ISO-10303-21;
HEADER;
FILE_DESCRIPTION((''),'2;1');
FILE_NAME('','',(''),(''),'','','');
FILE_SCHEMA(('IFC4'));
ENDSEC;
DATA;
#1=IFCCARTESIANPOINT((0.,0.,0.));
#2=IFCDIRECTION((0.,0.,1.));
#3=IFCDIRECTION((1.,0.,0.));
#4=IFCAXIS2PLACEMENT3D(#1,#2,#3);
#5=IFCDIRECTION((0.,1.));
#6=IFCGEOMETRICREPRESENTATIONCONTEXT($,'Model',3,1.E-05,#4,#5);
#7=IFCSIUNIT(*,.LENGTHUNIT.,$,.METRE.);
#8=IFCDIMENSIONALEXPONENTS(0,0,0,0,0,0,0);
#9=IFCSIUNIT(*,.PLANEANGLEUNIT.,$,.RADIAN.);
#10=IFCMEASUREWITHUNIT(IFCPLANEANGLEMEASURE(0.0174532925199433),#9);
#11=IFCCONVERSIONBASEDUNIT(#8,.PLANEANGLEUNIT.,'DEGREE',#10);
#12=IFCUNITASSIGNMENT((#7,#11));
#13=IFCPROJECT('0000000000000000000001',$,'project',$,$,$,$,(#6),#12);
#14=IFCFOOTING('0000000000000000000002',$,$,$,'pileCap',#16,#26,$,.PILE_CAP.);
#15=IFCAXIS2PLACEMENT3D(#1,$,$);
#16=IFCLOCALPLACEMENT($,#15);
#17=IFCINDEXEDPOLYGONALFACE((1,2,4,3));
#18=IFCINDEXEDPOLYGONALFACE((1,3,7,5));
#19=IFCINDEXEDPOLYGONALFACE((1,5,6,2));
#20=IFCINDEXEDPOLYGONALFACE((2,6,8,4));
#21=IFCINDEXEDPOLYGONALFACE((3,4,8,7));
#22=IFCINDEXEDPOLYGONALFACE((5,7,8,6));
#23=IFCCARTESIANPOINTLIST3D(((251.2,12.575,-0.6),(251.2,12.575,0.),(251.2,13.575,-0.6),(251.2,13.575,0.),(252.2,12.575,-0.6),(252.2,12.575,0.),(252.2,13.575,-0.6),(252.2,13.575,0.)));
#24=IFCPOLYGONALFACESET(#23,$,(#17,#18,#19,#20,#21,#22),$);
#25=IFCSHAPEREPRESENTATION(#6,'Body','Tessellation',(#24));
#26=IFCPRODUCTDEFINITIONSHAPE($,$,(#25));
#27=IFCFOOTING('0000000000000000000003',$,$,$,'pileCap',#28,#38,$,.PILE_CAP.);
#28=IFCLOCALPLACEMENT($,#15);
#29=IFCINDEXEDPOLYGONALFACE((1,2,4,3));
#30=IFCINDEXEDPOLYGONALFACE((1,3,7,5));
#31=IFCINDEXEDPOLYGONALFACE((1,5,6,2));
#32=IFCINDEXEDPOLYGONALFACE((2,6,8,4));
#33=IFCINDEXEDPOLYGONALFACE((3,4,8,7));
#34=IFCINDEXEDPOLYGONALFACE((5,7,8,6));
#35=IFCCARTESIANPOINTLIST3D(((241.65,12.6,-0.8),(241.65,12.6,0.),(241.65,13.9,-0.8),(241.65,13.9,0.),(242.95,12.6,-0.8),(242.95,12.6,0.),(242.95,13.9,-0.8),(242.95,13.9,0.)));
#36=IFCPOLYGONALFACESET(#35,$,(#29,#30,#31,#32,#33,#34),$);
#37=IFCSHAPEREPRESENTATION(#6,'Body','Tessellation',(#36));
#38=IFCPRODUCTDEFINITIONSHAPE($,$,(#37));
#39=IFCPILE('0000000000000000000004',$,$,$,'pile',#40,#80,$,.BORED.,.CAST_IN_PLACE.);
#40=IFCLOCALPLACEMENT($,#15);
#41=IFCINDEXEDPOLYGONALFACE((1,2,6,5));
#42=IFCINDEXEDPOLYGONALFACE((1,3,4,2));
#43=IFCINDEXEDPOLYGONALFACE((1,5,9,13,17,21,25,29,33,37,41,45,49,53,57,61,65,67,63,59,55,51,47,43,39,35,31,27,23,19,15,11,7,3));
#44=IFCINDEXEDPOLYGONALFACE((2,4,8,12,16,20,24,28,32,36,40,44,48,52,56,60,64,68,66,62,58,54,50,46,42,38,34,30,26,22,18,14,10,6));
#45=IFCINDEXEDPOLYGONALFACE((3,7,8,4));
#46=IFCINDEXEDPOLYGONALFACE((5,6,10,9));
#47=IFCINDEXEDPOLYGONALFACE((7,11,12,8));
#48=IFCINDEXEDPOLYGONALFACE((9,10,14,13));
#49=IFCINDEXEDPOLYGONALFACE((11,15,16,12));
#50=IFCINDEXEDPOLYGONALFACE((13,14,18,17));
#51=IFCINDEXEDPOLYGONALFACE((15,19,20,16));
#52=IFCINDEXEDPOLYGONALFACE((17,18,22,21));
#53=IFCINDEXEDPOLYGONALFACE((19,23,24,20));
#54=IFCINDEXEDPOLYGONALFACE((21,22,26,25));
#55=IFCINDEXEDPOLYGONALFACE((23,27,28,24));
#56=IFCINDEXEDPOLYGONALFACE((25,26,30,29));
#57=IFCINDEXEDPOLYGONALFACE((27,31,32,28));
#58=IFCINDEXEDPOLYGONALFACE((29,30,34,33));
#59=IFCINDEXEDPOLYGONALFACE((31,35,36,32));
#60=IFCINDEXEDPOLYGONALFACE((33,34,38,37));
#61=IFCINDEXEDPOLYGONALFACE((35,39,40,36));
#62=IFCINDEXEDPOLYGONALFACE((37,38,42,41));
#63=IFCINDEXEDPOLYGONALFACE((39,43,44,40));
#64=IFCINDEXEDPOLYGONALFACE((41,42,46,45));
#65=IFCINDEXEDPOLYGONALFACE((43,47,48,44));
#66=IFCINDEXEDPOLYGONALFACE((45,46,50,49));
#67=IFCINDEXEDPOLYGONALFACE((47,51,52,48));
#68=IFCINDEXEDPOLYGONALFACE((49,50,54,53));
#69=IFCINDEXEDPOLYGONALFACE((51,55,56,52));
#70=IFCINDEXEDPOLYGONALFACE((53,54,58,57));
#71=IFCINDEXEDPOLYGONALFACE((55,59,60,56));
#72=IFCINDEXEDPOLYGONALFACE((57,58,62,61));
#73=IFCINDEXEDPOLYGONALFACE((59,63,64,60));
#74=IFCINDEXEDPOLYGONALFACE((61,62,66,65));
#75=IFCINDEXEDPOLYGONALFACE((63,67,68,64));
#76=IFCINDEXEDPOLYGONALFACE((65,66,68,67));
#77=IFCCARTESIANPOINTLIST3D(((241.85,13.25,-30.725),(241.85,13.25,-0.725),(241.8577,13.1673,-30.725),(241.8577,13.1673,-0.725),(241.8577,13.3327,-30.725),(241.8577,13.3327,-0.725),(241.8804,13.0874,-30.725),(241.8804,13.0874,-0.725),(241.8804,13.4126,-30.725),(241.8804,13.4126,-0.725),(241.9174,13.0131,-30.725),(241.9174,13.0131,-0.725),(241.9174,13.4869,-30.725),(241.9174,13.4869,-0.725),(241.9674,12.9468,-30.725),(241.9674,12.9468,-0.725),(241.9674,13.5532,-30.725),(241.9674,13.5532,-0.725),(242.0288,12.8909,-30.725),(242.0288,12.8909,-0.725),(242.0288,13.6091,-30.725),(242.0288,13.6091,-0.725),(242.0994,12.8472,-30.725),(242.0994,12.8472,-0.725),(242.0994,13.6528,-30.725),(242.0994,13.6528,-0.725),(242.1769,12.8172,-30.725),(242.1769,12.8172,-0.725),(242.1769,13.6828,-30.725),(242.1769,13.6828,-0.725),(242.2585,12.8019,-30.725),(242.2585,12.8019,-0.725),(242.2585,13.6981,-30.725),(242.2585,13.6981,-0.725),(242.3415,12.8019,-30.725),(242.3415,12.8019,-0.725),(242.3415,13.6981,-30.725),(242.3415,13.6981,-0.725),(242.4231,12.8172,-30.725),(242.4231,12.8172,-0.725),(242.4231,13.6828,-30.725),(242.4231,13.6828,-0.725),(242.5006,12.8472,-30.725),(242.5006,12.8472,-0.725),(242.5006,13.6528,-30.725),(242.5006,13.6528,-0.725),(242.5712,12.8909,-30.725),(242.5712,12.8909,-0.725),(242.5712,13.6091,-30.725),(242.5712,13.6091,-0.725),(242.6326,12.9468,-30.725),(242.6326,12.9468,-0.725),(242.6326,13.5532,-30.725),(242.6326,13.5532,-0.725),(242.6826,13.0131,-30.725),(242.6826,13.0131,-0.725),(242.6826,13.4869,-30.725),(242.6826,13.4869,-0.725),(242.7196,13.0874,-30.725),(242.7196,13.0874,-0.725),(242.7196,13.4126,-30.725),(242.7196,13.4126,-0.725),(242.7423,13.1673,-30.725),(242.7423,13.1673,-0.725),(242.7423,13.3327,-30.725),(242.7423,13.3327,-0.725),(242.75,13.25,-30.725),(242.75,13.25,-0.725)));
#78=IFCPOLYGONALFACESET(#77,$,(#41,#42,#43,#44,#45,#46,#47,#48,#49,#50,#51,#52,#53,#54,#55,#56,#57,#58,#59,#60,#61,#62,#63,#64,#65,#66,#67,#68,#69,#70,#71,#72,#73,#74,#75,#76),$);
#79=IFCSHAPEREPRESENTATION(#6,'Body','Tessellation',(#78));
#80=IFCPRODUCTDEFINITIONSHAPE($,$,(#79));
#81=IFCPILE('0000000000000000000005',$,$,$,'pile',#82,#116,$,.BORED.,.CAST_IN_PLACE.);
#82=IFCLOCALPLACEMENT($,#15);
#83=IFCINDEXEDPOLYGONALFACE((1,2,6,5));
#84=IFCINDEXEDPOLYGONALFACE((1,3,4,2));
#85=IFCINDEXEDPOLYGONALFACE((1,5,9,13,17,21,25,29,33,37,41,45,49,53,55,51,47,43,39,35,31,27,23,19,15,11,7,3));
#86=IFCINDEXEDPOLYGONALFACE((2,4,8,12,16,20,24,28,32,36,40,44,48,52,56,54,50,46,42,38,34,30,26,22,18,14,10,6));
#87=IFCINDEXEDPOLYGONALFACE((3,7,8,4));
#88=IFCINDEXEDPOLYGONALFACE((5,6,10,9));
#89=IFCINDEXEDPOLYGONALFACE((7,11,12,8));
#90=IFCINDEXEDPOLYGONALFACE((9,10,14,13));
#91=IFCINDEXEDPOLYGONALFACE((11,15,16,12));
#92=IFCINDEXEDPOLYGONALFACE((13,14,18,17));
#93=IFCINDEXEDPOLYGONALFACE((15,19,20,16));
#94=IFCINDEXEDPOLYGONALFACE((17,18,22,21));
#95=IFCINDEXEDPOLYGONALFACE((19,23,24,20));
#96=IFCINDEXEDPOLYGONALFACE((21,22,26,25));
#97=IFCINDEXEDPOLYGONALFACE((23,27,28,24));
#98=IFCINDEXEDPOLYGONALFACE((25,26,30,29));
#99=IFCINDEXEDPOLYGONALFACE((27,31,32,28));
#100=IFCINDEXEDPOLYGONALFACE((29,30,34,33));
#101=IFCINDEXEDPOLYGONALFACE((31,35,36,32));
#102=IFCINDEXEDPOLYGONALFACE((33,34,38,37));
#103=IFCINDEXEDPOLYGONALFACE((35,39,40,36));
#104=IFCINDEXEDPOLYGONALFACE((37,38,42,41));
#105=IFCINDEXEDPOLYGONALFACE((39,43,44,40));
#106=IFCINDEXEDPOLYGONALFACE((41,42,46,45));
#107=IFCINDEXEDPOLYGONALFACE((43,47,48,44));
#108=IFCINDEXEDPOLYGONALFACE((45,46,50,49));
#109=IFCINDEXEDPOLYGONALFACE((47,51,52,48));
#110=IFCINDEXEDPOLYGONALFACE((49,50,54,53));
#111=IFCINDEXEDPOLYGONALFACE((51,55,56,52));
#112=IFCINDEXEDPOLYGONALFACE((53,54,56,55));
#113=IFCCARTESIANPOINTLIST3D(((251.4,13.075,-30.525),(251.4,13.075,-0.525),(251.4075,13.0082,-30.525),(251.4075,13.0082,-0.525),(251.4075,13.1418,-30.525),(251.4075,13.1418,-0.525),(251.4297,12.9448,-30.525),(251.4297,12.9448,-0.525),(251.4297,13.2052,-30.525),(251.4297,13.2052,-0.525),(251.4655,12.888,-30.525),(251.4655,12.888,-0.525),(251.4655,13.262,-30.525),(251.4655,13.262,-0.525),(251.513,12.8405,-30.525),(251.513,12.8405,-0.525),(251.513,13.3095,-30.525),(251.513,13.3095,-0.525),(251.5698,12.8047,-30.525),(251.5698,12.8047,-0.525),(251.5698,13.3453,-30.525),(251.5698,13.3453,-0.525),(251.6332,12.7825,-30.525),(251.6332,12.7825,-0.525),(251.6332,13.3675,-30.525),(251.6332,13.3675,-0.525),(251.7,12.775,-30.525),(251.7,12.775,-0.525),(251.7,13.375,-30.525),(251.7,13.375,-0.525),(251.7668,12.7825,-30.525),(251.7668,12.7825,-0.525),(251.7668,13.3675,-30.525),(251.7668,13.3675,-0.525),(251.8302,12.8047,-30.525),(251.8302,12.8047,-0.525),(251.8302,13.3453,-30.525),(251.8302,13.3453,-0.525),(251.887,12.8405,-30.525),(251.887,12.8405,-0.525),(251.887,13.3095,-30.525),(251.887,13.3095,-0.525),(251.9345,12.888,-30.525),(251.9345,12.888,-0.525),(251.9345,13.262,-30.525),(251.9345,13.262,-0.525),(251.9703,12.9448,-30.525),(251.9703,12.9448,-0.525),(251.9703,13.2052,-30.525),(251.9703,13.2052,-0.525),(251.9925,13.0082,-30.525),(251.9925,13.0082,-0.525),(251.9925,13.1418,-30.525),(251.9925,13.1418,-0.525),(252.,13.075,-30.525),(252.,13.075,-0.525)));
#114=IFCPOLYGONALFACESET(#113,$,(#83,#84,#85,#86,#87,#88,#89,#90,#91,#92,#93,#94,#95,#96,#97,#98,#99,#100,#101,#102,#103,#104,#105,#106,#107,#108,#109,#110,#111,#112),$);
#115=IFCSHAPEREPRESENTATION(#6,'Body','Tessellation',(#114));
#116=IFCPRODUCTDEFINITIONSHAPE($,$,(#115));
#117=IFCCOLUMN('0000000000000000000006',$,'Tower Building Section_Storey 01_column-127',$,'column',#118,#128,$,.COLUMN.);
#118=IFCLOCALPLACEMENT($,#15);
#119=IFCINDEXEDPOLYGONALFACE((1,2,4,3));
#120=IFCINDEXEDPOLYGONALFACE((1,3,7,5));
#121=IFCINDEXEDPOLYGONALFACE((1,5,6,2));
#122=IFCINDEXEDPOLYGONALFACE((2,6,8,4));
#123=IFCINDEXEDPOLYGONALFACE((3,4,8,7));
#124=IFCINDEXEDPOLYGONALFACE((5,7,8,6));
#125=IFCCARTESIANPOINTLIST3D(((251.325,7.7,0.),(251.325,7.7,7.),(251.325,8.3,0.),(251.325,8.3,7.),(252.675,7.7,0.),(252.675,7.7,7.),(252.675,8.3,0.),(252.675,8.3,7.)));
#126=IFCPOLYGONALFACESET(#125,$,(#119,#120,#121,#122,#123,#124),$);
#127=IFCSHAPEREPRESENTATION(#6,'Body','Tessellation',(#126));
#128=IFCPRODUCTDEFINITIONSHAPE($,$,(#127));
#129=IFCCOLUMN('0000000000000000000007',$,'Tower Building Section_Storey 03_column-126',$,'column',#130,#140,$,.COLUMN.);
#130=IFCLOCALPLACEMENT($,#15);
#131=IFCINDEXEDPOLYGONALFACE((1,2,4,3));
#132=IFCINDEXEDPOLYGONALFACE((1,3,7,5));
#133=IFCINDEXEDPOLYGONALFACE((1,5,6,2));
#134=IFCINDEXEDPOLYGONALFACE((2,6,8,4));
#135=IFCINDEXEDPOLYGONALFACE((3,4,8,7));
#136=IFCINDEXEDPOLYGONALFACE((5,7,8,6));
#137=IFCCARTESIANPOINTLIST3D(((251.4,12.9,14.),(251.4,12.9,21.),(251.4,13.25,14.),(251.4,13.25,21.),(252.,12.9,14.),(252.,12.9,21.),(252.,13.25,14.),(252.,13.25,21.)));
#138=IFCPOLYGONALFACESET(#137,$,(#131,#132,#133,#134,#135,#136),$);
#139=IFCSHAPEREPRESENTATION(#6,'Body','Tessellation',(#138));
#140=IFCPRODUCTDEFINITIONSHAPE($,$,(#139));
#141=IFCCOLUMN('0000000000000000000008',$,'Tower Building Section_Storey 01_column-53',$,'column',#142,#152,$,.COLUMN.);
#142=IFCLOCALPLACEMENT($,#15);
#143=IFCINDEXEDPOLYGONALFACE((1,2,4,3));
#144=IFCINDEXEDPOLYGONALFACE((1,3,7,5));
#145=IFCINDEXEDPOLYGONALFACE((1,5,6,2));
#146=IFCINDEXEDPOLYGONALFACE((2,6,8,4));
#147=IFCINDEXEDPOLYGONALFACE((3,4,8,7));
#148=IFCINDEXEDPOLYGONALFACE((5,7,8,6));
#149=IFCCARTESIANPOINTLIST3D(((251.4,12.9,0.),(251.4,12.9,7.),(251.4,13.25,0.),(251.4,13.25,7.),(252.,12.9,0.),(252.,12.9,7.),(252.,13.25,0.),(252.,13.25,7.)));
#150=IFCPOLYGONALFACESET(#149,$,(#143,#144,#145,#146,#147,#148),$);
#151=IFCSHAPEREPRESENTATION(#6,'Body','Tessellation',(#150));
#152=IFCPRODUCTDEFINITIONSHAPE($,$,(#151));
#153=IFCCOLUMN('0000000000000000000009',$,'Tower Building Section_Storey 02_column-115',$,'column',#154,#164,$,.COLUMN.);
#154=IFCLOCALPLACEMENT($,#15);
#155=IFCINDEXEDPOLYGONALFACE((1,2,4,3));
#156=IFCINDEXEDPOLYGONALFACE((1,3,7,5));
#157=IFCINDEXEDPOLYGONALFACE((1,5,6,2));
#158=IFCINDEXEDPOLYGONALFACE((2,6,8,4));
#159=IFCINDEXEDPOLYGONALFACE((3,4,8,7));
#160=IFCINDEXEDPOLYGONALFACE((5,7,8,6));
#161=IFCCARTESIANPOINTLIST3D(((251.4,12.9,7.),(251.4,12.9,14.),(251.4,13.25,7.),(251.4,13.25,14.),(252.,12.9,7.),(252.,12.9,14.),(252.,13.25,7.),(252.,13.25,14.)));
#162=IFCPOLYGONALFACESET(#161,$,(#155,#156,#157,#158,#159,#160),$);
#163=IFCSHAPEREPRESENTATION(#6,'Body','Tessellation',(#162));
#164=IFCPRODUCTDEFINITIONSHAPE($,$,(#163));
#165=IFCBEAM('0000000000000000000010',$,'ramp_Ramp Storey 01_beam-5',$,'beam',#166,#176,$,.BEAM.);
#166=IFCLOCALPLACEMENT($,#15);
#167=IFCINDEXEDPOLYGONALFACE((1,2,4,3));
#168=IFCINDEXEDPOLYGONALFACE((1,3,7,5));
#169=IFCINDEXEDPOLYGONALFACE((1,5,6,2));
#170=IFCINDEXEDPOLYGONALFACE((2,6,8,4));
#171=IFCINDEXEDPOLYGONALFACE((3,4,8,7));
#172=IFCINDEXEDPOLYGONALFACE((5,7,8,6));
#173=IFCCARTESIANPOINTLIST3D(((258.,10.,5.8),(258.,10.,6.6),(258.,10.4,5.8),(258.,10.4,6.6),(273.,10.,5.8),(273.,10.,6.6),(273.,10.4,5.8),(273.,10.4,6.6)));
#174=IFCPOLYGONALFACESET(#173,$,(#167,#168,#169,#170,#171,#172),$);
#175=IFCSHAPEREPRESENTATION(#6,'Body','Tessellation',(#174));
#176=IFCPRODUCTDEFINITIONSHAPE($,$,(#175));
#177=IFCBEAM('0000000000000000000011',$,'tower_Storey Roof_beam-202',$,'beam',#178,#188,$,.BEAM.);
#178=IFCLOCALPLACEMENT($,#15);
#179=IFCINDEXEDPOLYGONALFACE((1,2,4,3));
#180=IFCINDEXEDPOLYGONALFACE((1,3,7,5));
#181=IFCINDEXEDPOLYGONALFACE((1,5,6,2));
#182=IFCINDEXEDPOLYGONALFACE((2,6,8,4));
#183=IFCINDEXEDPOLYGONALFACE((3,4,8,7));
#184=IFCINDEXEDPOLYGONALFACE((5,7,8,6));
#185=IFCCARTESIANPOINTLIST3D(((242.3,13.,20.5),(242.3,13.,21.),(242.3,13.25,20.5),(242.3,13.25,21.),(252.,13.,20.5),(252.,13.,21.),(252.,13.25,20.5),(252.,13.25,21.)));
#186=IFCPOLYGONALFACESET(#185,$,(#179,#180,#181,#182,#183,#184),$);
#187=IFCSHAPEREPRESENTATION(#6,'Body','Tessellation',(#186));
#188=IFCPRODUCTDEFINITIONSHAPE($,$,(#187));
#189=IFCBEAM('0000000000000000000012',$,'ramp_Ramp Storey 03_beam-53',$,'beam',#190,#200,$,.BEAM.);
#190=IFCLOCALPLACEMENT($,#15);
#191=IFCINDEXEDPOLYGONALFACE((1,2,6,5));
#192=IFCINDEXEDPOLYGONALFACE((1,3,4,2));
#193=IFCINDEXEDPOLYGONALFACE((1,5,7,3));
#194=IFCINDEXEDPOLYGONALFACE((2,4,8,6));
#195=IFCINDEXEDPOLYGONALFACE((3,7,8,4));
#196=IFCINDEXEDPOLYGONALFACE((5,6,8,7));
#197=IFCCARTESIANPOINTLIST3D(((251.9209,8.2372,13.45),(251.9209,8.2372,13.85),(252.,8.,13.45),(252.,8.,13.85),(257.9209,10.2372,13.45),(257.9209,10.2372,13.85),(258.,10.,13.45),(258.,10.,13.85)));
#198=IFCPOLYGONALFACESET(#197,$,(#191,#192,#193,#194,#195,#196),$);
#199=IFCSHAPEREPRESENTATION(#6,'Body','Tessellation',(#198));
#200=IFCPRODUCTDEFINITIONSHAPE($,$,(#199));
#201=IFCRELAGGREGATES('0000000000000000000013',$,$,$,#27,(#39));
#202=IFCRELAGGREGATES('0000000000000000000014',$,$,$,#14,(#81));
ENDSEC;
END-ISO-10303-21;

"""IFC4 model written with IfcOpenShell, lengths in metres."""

from ifc_helpers import new_model, entity, si_unit, converted_unit, direction, frame, origin_with_axes, place, context, project, polyline, circle_curve, parameter, trimmed, segment, composite_curve, outline, extrude, element, aggregate, save


model = new_model("IFC4")

# Units and contexts
model_context = context("Model", 3, precision=1e-05, world=origin_with_axes(), true_north=direction((0.0, 1.0)))
ifc_project = project(units=[si_unit("LENGTHUNIT", "METRE"), converted_unit("PLANEANGLEUNIT", "DEGREE", entity("IfcPlaneAngleMeasure", 0.0174532925199433), si_unit("PLANEANGLEUNIT", "RADIAN"), dimensions=[0, 0, 0, 0, 0, 0, 0])], contexts=[model_context])

# Footing
placement_1 = place(None, origin_with_axes())
placement_2 = place(placement_1, origin_with_axes())
footing_1_placement = place(placement_2, frame((251.7, 13.075, -0.6), z_axis=(0.0, 0.0, 1.0), x_axis=(1.0, 0.0, 0.0)))
footing_1 = element("IfcFooting", 1, at=footing_1_placement, ObjectType="pileCap", PredefinedType="PILE_CAP", context=model_context, body=[
    extrude(outline(polyline([(0.5, -0.5, 0.0), (0.5, 0.5, 0.0), (-0.5, 0.5, 0.0), (-0.5, -0.5, 0.0), (0.5, -0.5, 0.0)])), origin_with_axes(), (0.0, 0.0, 1.0), 0.6),
])

# Footing, pile
footing_2_placement = place(placement_2, frame((242.3, 13.25, -0.8), z_axis=(0.0, 0.0, 1.0), x_axis=(1.0, 0.0, 0.0)))
footing_2 = element("IfcFooting", 2, at=footing_2_placement, ObjectType="pileCap", PredefinedType="PILE_CAP", context=model_context, body=[
    extrude(outline(polyline([(0.65, -0.65, 0.0), (0.65, 0.65, 0.0), (-0.65, 0.65, 0.0), (-0.65, -0.65, 0.0), (0.65, -0.65, 0.0)])), origin_with_axes(), (0.0, 0.0, 1.0), 0.8),
])
pile_1_placement = place(footing_2_placement, frame((0.0, 0.0, -29.925), z_axis=(0.0, 0.0, 1.0), x_axis=(1.0, 0.0, 0.0)))
pile_1 = element("IfcPile", 3, at=pile_1_placement, ObjectType="pile", ConstructionType="CAST_IN_PLACE", PredefinedType="BORED", context=model_context, body=[
    extrude(outline(composite_curve([segment(trimmed(circle_curve(origin_with_axes(), 0.45), [parameter(0.0)], [parameter(360.0)], True, "PARAMETER"), True, "CONTINUOUS")], self_intersect=False)), origin_with_axes(), (0.0, 0.0, 1.0), 30.0),
])
aggregate(footing_2, [pile_1])

# Pile
pile_2_placement = place(footing_1_placement, frame((0.0, 0.0, -29.925), z_axis=(0.0, 0.0, 1.0), x_axis=(1.0, 0.0, 0.0)))
pile_2 = element("IfcPile", 4, at=pile_2_placement, ObjectType="pile", ConstructionType="CAST_IN_PLACE", PredefinedType="BORED", context=model_context, body=[
    extrude(outline(composite_curve([segment(trimmed(circle_curve(origin_with_axes(), 0.3), [parameter(0.0)], [parameter(360.0)], True, "PARAMETER"), True, "CONTINUOUS")], self_intersect=False)), origin_with_axes(), (0.0, 0.0, 1.0), 30.0),
])
aggregate(footing_1, [pile_2])

# Columns
column_1_placement = place(placement_2, frame((252.0, 8.0, 0.0), z_axis=(0.0, 0.0, 1.0), x_axis=(1.0, 0.0, 0.0)))
element("IfcColumn", 5, at=column_1_placement, Name="Tower Building Section_Storey 01_column-127", ObjectType="column", PredefinedType="COLUMN", context=model_context, body=[
    extrude(outline(polyline([(-0.675, -0.3, 0.0), (0.675, -0.3, 0.0), (0.675, 0.3, 0.0), (-0.675, 0.3, 0.0), (-0.675, -0.3, 0.0)])), origin_with_axes(), (0.0, 0.0, 1.0), 7.0),
])
placement_3 = place(placement_1, frame((0.0, 0.0, 14.0), z_axis=(0.0, 0.0, 1.0), x_axis=(1.0, 0.0, 0.0)))
column_2_placement = place(placement_3, frame((251.7, 13.075, 0.0), z_axis=(0.0, 0.0, 1.0), x_axis=(1.0, 0.0, 0.0)))
element("IfcColumn", 6, at=column_2_placement, Name="Tower Building Section_Storey 03_column-126", ObjectType="column", PredefinedType="COLUMN", context=model_context, body=[
    extrude(outline(polyline([(-0.3, -0.175, 0.0), (0.3, -0.175, 0.0), (0.3, 0.175, 0.0), (-0.3, 0.175, 0.0), (-0.3, -0.175, 0.0)])), origin_with_axes(), (0.0, 0.0, 1.0), 7.0),
])
column_3_placement = place(placement_2, frame((251.7, 13.075, 0.0), z_axis=(0.0, 0.0, 1.0), x_axis=(1.0, 0.0, 0.0)))
element("IfcColumn", 7, at=column_3_placement, Name="Tower Building Section_Storey 01_column-53", ObjectType="column", PredefinedType="COLUMN", context=model_context, body=[
    extrude(outline(polyline([(-0.3, -0.175, 0.0), (0.3, -0.175, 0.0), (0.3, 0.175, 0.0), (-0.3, 0.175, 0.0), (-0.3, -0.175, 0.0)])), origin_with_axes(), (0.0, 0.0, 1.0), 7.0),
])
placement_4 = place(placement_1, frame((0.0, 0.0, 7.0), z_axis=(0.0, 0.0, 1.0), x_axis=(1.0, 0.0, 0.0)))
column_4_placement = place(placement_4, frame((251.7, 13.075, 0.0), z_axis=(0.0, 0.0, 1.0), x_axis=(1.0, 0.0, 0.0)))
element("IfcColumn", 8, at=column_4_placement, Name="Tower Building Section_Storey 02_column-115", ObjectType="column", PredefinedType="COLUMN", context=model_context, body=[
    extrude(outline(polyline([(-0.3, -0.175, 0.0), (0.3, -0.175, 0.0), (0.3, 0.175, 0.0), (-0.3, 0.175, 0.0), (-0.3, -0.175, 0.0)])), origin_with_axes(), (0.0, 0.0, 1.0), 7.0),
])

# Beams
placement_5 = place(None, frame((258.0, -8.0, 0.0), z_axis=(0.0, 0.0, 1.0), x_axis=(1.0, 0.0, 0.0)))
placement_6 = place(placement_5, origin_with_axes())
beam_1_placement = place(placement_6, frame((0.0, 18.2, 6.2), z_axis=(1.0, 0.0, 0.0), x_axis=(0.0, 1.0, 0.0)))
element("IfcBeam", 9, at=beam_1_placement, Name="ramp_Ramp Storey 01_beam-5", ObjectType="beam", PredefinedType="BEAM", context=model_context, body=[
    extrude(outline(polyline([(0.2, 0.4, 0.0), (-0.2, 0.4, 0.0), (-0.2, -0.4, 0.0), (0.2, -0.4, 0.0), (0.2, 0.4, 0.0)])), origin_with_axes(), (0.0, 0.0, 1.0), 15.0),
])
placement_7 = place(placement_1, frame((0.0, 0.0, 21.0), z_axis=(0.0, 0.0, 1.0), x_axis=(1.0, 0.0, 0.0)))
beam_2_placement = place(placement_7, frame((242.3, 13.125, -0.25), z_axis=(1.0, 0.0, 0.0), x_axis=(0.0, 1.0, 0.0)))
element("IfcBeam", 10, at=beam_2_placement, Name="tower_Storey Roof_beam-202", ObjectType="beam", PredefinedType="BEAM", context=model_context, body=[
    extrude(outline(polyline([(0.125, 0.25, 0.0), (-0.125, 0.25, 0.0), (-0.125, -0.25, 0.0), (0.125, -0.25, 0.0), (0.125, 0.25, 0.0)])), origin_with_axes(), (0.0, 0.0, 1.0), 9.7),
])
placement_8 = place(placement_5, frame((0.0, 0.0, 14.0), z_axis=(0.0, 0.0, 1.0), x_axis=(1.0, 0.0, 0.0)))
beam_3_placement = place(placement_8, frame((-6.0395, 16.1186, -0.35), z_axis=(0.948683, 0.316228, 0.0), x_axis=(-0.316228, 0.948683, 0.0)))
element("IfcBeam", 11, at=beam_3_placement, Name="ramp_Ramp Storey 03_beam-53", ObjectType="beam", PredefinedType="BEAM", context=model_context, body=[
    extrude(outline(polyline([(0.125, 0.2, 0.0), (-0.125, 0.2, 0.0), (-0.125, -0.2, 0.0), (0.125, -0.2, 0.0), (0.125, 0.2, 0.0)])), origin_with_axes(), (0.0, 0.0, 1.0), 6.3246),
])

save(model, "model.ifc")
